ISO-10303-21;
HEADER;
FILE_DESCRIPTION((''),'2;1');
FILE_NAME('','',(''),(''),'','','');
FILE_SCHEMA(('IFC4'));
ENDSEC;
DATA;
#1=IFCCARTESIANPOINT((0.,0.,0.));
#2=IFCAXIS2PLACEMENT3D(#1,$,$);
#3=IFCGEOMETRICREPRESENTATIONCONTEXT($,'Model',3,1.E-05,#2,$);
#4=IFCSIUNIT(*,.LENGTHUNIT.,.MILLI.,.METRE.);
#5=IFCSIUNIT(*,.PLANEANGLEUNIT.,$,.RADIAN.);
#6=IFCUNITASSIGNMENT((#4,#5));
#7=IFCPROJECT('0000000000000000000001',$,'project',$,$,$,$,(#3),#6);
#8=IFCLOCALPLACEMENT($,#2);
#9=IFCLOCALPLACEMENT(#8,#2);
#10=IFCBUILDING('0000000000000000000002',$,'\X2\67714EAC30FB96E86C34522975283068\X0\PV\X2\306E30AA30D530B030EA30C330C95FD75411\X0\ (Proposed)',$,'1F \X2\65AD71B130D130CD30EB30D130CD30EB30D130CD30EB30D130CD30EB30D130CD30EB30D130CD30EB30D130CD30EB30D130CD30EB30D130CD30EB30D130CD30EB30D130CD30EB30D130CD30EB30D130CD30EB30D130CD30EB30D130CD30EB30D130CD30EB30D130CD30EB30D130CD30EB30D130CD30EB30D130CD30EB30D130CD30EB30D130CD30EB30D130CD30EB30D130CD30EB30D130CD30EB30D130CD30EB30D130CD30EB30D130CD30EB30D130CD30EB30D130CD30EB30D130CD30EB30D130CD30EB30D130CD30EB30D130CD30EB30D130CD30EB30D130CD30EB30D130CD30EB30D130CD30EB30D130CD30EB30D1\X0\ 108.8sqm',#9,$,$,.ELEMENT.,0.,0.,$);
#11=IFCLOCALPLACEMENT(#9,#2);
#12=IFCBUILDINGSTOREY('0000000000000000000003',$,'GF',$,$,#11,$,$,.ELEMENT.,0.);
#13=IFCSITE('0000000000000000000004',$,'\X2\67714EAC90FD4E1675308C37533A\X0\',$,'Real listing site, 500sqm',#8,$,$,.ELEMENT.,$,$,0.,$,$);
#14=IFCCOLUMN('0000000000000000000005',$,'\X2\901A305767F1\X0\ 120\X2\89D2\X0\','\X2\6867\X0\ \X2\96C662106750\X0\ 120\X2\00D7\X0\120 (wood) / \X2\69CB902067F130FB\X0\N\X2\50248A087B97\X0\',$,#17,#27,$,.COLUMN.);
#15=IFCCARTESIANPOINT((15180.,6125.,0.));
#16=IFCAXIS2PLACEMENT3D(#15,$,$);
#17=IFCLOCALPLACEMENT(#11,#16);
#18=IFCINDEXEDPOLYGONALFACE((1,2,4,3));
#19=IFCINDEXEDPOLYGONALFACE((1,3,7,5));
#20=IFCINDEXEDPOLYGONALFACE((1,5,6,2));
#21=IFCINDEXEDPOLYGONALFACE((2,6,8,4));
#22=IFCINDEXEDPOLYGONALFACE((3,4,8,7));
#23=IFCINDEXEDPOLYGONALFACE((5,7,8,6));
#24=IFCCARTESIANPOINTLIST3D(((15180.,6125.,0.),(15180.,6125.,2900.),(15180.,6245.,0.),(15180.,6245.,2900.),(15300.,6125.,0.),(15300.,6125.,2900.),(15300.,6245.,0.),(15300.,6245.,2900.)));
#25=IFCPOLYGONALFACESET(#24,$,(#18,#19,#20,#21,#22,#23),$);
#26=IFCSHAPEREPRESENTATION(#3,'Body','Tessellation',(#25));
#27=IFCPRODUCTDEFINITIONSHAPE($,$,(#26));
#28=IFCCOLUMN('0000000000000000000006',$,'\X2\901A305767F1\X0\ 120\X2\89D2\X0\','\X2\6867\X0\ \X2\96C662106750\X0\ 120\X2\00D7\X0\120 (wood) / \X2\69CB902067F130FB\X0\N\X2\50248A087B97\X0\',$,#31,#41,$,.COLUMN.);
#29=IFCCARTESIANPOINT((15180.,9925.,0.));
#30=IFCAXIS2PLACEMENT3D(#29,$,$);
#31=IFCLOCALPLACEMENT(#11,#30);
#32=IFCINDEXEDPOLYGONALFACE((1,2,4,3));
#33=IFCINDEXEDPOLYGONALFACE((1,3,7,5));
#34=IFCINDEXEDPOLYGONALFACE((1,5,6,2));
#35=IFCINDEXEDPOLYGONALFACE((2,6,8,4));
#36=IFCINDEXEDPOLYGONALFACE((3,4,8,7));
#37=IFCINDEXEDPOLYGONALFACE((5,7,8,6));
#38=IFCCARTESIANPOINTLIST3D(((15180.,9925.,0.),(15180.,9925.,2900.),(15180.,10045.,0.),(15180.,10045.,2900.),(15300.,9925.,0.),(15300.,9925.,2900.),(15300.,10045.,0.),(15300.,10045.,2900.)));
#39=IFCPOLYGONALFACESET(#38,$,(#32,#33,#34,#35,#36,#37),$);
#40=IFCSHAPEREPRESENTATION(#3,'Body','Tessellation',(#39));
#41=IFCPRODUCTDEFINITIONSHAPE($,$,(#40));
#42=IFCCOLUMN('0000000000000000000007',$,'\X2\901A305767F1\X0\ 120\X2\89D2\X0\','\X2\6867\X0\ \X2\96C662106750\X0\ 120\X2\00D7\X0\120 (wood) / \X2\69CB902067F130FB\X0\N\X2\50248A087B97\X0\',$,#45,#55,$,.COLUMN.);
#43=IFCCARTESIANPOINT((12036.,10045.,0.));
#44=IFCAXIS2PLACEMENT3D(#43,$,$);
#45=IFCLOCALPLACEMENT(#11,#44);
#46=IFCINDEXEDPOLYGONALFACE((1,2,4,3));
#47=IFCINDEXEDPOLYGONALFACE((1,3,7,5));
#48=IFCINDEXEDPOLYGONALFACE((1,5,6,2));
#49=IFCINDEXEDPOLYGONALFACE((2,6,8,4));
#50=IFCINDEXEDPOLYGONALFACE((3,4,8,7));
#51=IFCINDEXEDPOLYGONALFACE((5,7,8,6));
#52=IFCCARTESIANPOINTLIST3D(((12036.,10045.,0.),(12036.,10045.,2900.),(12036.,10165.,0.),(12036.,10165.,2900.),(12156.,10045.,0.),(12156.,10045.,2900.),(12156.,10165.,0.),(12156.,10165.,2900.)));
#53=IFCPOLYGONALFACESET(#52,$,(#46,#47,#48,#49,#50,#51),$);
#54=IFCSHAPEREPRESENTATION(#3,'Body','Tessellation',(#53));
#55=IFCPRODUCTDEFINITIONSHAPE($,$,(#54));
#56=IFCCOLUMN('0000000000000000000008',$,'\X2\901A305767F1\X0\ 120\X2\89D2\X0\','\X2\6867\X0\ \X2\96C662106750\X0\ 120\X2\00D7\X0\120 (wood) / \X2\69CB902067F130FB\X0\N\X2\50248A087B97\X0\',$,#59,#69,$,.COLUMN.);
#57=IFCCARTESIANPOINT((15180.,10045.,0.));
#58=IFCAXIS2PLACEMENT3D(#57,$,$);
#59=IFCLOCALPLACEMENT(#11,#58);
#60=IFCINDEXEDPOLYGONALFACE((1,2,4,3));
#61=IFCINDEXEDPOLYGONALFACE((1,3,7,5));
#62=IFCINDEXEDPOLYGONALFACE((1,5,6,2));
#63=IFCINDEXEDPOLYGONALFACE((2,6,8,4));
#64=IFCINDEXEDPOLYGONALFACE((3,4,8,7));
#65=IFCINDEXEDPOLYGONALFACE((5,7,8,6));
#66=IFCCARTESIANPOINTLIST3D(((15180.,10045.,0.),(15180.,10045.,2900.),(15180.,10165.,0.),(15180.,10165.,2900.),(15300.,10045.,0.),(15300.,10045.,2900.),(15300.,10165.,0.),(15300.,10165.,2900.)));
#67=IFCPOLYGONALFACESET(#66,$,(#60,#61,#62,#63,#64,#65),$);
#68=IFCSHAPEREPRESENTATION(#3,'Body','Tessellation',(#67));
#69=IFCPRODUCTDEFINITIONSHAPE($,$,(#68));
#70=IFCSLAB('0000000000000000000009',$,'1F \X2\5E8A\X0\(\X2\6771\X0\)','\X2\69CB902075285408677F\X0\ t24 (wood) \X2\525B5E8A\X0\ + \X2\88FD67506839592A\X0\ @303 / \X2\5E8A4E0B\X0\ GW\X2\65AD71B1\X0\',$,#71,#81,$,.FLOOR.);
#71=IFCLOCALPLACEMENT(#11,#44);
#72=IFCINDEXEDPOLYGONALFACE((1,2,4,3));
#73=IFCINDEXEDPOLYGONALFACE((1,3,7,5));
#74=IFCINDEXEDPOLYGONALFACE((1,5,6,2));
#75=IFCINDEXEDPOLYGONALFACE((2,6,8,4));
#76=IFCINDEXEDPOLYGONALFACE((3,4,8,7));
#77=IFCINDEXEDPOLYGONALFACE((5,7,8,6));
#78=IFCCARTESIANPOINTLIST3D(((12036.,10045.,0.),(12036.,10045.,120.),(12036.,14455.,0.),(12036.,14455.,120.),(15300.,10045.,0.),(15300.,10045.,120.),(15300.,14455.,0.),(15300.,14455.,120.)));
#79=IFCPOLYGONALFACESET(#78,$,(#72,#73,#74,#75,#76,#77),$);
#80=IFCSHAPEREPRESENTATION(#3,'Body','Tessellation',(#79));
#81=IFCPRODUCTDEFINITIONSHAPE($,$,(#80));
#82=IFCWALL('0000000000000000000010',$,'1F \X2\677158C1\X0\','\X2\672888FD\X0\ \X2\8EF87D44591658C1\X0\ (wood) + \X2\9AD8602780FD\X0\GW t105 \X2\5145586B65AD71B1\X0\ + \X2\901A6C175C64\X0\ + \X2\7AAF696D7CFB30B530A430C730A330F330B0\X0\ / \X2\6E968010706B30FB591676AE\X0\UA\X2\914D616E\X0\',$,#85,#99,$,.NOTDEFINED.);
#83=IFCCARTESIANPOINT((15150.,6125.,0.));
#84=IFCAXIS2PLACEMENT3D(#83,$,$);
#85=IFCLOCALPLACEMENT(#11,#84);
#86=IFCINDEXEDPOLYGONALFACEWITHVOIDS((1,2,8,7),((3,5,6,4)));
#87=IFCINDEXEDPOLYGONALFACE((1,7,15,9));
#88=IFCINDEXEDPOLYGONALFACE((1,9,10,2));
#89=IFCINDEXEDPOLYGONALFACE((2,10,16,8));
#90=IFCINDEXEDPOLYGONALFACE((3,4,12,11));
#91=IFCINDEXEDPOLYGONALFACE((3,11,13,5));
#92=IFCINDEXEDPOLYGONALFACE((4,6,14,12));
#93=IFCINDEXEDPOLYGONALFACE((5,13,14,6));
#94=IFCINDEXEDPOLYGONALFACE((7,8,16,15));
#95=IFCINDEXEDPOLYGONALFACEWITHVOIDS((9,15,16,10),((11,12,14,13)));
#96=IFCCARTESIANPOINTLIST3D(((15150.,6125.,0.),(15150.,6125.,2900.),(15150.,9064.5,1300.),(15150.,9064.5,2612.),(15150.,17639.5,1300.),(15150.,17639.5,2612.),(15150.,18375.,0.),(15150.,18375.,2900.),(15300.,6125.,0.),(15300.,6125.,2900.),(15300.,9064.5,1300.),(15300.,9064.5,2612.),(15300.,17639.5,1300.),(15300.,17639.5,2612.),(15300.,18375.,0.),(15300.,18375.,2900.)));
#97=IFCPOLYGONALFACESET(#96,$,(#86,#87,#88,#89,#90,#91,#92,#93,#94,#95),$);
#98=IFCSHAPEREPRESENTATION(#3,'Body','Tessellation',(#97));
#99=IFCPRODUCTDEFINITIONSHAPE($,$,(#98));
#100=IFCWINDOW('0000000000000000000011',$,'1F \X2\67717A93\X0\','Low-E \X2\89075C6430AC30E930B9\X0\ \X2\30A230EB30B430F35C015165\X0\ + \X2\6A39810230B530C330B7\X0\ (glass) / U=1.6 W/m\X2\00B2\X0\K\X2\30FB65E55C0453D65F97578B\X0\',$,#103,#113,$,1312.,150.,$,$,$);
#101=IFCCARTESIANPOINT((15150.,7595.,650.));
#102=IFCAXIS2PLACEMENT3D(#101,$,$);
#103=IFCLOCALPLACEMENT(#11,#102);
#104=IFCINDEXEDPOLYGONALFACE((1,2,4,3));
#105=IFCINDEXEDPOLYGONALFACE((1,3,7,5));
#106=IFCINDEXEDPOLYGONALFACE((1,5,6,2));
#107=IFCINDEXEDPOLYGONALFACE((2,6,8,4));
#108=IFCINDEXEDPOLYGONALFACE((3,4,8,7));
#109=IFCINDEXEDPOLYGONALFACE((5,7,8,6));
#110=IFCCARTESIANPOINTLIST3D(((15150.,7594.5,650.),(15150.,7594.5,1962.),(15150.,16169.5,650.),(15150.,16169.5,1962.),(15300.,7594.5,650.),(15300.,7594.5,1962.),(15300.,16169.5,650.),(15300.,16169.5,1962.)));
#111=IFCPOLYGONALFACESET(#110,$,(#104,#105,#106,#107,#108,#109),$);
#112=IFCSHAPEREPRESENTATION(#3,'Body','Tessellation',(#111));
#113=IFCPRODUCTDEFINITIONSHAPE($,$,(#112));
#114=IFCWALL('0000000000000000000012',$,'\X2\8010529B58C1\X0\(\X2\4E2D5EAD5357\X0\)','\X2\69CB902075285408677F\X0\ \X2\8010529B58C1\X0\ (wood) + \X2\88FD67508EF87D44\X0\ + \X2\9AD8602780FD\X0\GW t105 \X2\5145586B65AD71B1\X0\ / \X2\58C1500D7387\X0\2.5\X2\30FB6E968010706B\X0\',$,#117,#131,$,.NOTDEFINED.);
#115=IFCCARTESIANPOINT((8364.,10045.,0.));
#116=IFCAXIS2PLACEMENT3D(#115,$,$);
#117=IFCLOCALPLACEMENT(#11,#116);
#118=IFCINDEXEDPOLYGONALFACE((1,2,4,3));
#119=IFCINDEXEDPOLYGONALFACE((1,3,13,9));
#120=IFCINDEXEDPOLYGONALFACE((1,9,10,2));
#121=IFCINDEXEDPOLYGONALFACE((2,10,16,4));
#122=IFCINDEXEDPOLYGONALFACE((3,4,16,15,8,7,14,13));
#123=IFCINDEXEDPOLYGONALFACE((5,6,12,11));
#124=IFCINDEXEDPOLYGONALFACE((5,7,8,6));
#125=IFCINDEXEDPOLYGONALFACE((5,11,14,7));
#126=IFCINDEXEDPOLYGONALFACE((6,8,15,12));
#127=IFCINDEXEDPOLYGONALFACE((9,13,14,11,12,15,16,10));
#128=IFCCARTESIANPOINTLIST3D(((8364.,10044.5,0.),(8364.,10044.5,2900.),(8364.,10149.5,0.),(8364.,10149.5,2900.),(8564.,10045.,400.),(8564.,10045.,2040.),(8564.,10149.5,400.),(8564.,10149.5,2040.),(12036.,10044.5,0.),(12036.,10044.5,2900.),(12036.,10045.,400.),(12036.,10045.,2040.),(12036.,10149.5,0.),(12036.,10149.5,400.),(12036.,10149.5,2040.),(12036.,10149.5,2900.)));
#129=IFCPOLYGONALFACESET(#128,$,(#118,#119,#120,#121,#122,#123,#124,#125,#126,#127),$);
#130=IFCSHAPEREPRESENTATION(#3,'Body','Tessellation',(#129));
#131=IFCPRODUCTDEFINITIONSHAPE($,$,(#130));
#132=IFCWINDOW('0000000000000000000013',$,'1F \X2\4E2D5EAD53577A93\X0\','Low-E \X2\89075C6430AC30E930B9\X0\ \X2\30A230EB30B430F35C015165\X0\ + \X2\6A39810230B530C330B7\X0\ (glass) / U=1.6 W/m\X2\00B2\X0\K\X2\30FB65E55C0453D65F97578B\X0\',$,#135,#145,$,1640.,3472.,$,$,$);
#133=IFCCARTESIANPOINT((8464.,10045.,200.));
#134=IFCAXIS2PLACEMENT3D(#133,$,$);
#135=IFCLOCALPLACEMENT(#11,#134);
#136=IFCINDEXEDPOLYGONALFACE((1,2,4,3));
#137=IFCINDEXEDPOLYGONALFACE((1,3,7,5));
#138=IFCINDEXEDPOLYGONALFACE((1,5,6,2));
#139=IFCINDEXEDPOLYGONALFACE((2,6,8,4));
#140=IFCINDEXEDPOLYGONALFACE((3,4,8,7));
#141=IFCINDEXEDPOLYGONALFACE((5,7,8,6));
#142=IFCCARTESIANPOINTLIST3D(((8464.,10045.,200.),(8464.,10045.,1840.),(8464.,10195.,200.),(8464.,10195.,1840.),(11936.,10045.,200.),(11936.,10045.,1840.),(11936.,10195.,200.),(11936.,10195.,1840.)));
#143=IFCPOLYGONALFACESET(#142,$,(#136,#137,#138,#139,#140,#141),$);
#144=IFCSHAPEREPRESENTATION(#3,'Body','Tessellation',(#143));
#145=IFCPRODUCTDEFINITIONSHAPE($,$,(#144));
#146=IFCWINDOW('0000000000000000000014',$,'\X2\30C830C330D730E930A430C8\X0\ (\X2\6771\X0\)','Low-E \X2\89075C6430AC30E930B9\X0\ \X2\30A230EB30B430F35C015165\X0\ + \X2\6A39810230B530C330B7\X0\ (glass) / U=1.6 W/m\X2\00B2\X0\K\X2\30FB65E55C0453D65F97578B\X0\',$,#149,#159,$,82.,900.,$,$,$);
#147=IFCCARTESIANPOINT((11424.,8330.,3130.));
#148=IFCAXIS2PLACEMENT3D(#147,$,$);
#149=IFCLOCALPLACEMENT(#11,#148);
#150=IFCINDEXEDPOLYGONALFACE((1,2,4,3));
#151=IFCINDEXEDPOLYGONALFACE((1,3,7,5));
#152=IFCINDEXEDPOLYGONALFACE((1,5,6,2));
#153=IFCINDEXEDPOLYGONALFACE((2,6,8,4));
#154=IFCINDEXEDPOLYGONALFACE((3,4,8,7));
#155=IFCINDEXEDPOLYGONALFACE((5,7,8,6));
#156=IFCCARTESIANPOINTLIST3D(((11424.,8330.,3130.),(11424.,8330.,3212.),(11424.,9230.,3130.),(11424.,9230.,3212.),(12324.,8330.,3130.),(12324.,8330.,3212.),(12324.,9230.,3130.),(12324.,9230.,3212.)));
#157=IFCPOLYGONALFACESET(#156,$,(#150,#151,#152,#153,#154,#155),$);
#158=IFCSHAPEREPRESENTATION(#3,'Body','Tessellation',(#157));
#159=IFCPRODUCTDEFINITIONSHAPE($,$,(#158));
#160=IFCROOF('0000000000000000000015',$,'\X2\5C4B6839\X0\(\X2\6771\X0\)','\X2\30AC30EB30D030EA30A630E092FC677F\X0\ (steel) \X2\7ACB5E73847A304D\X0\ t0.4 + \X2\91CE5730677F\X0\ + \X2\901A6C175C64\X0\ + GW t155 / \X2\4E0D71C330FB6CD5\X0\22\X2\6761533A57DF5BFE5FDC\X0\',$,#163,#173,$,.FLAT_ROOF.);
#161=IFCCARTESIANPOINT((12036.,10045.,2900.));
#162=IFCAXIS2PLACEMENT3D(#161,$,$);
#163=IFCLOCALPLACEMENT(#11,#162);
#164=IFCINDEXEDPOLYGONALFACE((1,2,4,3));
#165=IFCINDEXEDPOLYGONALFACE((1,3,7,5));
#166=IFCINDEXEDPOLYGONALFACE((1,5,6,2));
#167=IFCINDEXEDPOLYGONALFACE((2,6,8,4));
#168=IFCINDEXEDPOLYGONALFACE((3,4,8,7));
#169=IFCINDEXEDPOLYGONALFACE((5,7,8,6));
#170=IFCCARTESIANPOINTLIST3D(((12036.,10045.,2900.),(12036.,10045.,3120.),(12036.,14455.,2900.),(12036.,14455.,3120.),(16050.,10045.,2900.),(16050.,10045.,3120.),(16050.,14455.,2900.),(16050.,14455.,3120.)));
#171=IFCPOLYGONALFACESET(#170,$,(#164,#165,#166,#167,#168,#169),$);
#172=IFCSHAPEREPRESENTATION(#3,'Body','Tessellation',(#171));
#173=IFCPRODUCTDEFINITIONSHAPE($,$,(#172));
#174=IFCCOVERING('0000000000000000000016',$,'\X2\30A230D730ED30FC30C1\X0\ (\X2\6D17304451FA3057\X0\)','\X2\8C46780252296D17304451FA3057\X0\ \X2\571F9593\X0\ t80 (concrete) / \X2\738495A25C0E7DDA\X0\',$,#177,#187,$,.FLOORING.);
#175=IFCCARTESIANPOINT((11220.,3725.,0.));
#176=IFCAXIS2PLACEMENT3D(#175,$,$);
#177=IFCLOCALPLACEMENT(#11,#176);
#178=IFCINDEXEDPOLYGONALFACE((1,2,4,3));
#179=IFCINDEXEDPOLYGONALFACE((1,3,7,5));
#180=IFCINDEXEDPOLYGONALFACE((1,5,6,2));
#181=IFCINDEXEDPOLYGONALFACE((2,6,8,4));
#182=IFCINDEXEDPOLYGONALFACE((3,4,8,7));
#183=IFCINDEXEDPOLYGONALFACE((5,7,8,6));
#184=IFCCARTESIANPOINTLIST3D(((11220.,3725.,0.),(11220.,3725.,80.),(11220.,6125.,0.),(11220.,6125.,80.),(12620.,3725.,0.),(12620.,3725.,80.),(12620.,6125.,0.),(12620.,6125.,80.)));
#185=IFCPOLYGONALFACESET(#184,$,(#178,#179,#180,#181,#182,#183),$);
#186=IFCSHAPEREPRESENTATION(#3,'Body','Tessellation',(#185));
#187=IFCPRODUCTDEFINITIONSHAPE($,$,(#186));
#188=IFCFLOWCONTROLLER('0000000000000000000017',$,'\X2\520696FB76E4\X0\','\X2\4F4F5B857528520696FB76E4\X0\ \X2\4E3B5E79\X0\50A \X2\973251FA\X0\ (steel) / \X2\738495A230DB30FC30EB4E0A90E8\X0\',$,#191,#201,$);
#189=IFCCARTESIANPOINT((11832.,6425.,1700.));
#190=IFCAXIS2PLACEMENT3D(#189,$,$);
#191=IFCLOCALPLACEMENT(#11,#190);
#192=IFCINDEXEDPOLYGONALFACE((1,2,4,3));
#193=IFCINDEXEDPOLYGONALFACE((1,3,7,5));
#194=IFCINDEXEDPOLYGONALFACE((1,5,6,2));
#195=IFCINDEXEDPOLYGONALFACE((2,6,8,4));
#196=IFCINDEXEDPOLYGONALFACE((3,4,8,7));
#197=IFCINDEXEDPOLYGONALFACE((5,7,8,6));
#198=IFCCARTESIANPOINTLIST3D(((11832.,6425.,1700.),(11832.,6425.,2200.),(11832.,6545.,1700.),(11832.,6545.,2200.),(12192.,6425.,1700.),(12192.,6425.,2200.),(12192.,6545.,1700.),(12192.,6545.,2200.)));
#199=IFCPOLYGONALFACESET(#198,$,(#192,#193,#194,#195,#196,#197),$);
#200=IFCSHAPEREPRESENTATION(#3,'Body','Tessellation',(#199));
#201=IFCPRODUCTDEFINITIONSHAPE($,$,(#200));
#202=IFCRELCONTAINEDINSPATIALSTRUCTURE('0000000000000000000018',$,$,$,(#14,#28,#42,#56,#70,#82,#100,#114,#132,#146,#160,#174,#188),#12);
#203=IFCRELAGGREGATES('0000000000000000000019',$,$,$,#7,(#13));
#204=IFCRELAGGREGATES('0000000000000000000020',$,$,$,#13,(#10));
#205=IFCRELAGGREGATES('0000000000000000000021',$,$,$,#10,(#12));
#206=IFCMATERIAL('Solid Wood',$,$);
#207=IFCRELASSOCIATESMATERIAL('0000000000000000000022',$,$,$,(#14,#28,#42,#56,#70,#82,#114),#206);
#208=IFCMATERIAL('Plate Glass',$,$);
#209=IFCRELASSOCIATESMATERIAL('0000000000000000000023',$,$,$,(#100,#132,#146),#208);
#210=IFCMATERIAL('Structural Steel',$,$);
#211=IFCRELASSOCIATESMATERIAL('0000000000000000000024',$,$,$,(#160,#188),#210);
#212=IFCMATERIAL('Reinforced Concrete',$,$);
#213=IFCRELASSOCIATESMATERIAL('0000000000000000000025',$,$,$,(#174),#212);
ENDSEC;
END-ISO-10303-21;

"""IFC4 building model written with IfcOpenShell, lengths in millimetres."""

from ifc_helpers import new_model, si_unit, frame, frame_2d, origin, place, context, project, spatial, rectangle, extrude, material, element, fill, save


model = new_model("IFC4")

# Units and contexts
model_context = context("Model", 3, precision=1e-05, world=origin())
ifc_project = project(units=[si_unit("LENGTHUNIT", "METRE", prefix="MILLI"), si_unit("PLANEANGLEUNIT", "RADIAN")], contexts=[model_context])

# Site, building, storey
site_placement = place(None, origin())
site = spatial("IfcSite", under=ifc_project, at=site_placement, Name="東京都世田谷区", ObjectType="Real listing site, 500sqm", CompositionType="ELEMENT", RefElevation=0.0)
building_placement = place(site_placement, origin())
building = spatial("IfcBuilding", under=site, at=building_placement, Name="東京・雨水利用とPVのオフグリッド志向 (Proposed)", ObjectType="1F 断熱パネルパネルパネルパネルパネルパネルパネルパネルパネルパネルパネルパネルパネルパネルパネルパネルパネルパネルパネルパネルパネルパネルパネルパネルパネルパネルパネルパネルパネルパネルパネルパネルパネルパネルパネルパネルパネルパネルパネルパ 108.8sqm", CompositionType="ELEMENT", ElevationOfRefHeight=0.0, ElevationOfTerrain=0.0)
storey_placement = place(building_placement, origin())
storey = spatial("IfcBuildingStorey", under=building, at=storey_placement, Name="GF", CompositionType="ELEMENT", Elevation=0.0)

# Columns
ifc_material_1 = material(Name="Solid Wood")
column_1_placement = place(storey_placement, frame((15180.0, 6125.0, 0.0)))
element("IfcColumn", 1, at=column_1_placement, inside=storey, material=ifc_material_1, Name="通し柱 120角", Description="桧 集成材 120×120 (wood) / 構造柱・N値計算", PredefinedType="COLUMN", context=model_context, shape_type="SweptSolid", body=[
    extrude(rectangle(XDim=120.0, YDim=120.0, at=frame_2d((60.0, 60.0))), frame((15180.0, 6125.0, 0.0)), (0.0, 0.0, 1.0), 2900.0),
])
column_2_placement = place(storey_placement, frame((15180.0, 9925.0, 0.0)))
element("IfcColumn", 2, at=column_2_placement, inside=storey, material=ifc_material_1, Name="通し柱 120角", Description="桧 集成材 120×120 (wood) / 構造柱・N値計算", PredefinedType="COLUMN", context=model_context, shape_type="SweptSolid", body=[
    extrude(rectangle(XDim=120.0, YDim=120.0, at=frame_2d((60.0, 60.0))), frame((15180.0, 9925.0, 0.0)), (0.0, 0.0, 1.0), 2900.0),
])
column_3_placement = place(storey_placement, frame((12036.0, 10045.0, 0.0)))
element("IfcColumn", 3, at=column_3_placement, inside=storey, material=ifc_material_1, Name="通し柱 120角", Description="桧 集成材 120×120 (wood) / 構造柱・N値計算", PredefinedType="COLUMN", context=model_context, shape_type="SweptSolid", body=[
    extrude(rectangle(XDim=120.0, YDim=120.0, at=frame_2d((60.0, 60.0))), frame((12036.0, 10045.0, 0.0)), (0.0, 0.0, 1.0), 2900.0),
])
column_4_placement = place(storey_placement, frame((15180.0, 10045.0, 0.0)))
element("IfcColumn", 4, at=column_4_placement, inside=storey, material=ifc_material_1, Name="通し柱 120角", Description="桧 集成材 120×120 (wood) / 構造柱・N値計算", PredefinedType="COLUMN", context=model_context, shape_type="SweptSolid", body=[
    extrude(rectangle(XDim=120.0, YDim=120.0, at=frame_2d((60.0, 60.0))), frame((15180.0, 10045.0, 0.0)), (0.0, 0.0, 1.0), 2900.0),
])

# Slab
slab_placement = place(storey_placement, frame((12036.0, 10045.0, 0.0)))
element("IfcSlab", 5, at=slab_placement, inside=storey, material=ifc_material_1, Name="1F 床(東)", Description="構造用合板 t24 (wood) 剛床 + 製材根太 @303 / 床下 GW断熱", PredefinedType="FLOOR", context=model_context, shape_type="SweptSolid", body=[
    extrude(rectangle(XDim=3264.0, YDim=4410.0, at=frame_2d((1632.0, 2205.0))), frame((12036.0, 10045.0, 0.0)), (0.0, 0.0, 1.0), 120.0),
])

# Walls, openings, windows
wall_1_placement = place(storey_placement, frame((15150.0, 6125.0, 0.0)))
wall_1 = element("IfcWall", 6, at=wall_1_placement, inside=storey, material=ifc_material_1, Name="1F 東壁", Description="木製 軸組外壁 (wood) + 高性能GW t105 充填断熱 + 通気層 + 窯業系サイディング / 準耐火・外皮UA配慮", PredefinedType="NOTDEFINED", context=model_context, shape_type="SweptSolid", body=[
    extrude(rectangle(XDim=150.0, YDim=12250.0, at=frame_2d((75.0, 6125.0))), frame((15150.0, 6125.0, 0.0)), (0.0, 0.0, 1.0), 2900.0),
])
opening_1_placement = place(storey_placement, frame((15150.0, 7595.0, 650.0)))
opening_1 = element("IfcOpeningElement", 7, at=opening_1_placement, cuts=wall_1, PredefinedType="NOTDEFINED", context=model_context, shape_type="SweptSolid", body=[
    extrude(rectangle(XDim=150.0, YDim=8575.0, at=frame_2d((75.0, 4287.0))), frame((15150.0, 7595.0, 650.0)), (0.0, 0.0, 1.0), 1312.0),
])
ifc_material_2 = material(Name="Plate Glass")
window_1_placement = place(storey_placement, frame((15150.0, 7595.0, 650.0)))
window_1 = element("IfcWindow", 8, at=window_1_placement, inside=storey, material=ifc_material_2, Name="1F 東窓", Description="Low-E 複層ガラス アルゴン封入 + 樹脂サッシ (glass) / U=1.6 W/m²K・日射取得型", OverallHeight=1312.0, OverallWidth=150.0, context=model_context, shape_type="SweptSolid", body=[
    extrude(rectangle(XDim=150.0, YDim=8575.0, at=frame_2d((75.0, 4287.0))), frame((15150.0, 7595.0, 650.0)), (0.0, 0.0, 1.0), 1312.0),
])
fill(opening_1, window_1)
wall_2_placement = place(storey_placement, frame((8364.0, 10045.0, 0.0)))
wall_2 = element("IfcWall", 9, at=wall_2_placement, inside=storey, material=ifc_material_1, Name="耐力壁(中庭南)", Description="構造用合板 耐力壁 (wood) + 製材軸組 + 高性能GW t105 充填断熱 / 壁倍率2.5・準耐火", PredefinedType="NOTDEFINED", context=model_context, shape_type="SweptSolid", body=[
    extrude(rectangle(XDim=3672.0, YDim=105.0, at=frame_2d((1836.0, 52.0))), frame((8364.0, 10045.0, 0.0)), (0.0, 0.0, 1.0), 2900.0),
])
opening_2_placement = place(storey_placement, frame((8464.0, 10045.0, 200.0)))
opening_2 = element("IfcOpeningElement", 10, at=opening_2_placement, cuts=wall_2, PredefinedType="NOTDEFINED", context=model_context, shape_type="SweptSolid", body=[
    extrude(rectangle(XDim=3472.0, YDim=150.0, at=frame_2d((1736.0, 75.0))), frame((8464.0, 10045.0, 200.0)), (0.0, 0.0, 1.0), 1640.0),
])
window_2_placement = place(storey_placement, frame((8464.0, 10045.0, 200.0)))
window_2 = element("IfcWindow", 11, at=window_2_placement, inside=storey, material=ifc_material_2, Name="1F 中庭南窓", Description="Low-E 複層ガラス アルゴン封入 + 樹脂サッシ (glass) / U=1.6 W/m²K・日射取得型", OverallHeight=1640.0, OverallWidth=3472.0, context=model_context, shape_type="SweptSolid", body=[
    extrude(rectangle(XDim=3472.0, YDim=150.0, at=frame_2d((1736.0, 75.0))), frame((8464.0, 10045.0, 200.0)), (0.0, 0.0, 1.0), 1640.0),
])
fill(opening_2, window_2)

# Window
window_3_placement = place(storey_placement, frame((11424.0, 8330.0, 3130.0)))
element("IfcWindow", 12, at=window_3_placement, inside=storey, material=ifc_material_2, Name="トップライト (東)", Description="Low-E 複層ガラス アルゴン封入 + 樹脂サッシ (glass) / U=1.6 W/m²K・日射取得型", OverallHeight=82.0, OverallWidth=900.0, context=model_context, shape_type="SweptSolid", body=[
    extrude(rectangle(XDim=900.0, YDim=900.0, at=frame_2d((450.0, 450.0))), frame((11424.0, 8330.0, 3130.0)), (0.0, 0.0, 1.0), 82.0),
])

# Roof
ifc_material_3 = material(Name="Structural Steel")
roof_placement = place(storey_placement, frame((12036.0, 10045.0, 2900.0)))
element("IfcRoof", 13, at=roof_placement, inside=storey, material=ifc_material_3, Name="屋根(東)", Description="ガルバリウム鋼板 (steel) 立平葺き t0.4 + 野地板 + 通気層 + GW t155 / 不燃・法22条区域対応", PredefinedType="FLAT_ROOF", context=model_context, shape_type="SweptSolid", body=[
    extrude(rectangle(XDim=4014.0, YDim=4410.0, at=frame_2d((2007.0, 2205.0))), frame((12036.0, 10045.0, 2900.0)), (0.0, 0.0, 1.0), 220.0),
])

# Covering
ifc_material_4 = material(Name="Reinforced Concrete")
covering_placement = place(storey_placement, frame((11220.0, 3725.0, 0.0)))
element("IfcCovering", 14, at=covering_placement, inside=storey, material=ifc_material_4, Name="アプローチ (洗い出し)", Description="豆砂利洗い出し 土間 t80 (concrete) / 玄関導線", PredefinedType="FLOORING", context=model_context, shape_type="SweptSolid", body=[
    extrude(rectangle(XDim=1400.0, YDim=2400.0, at=frame_2d((700.0, 1200.0))), frame((11220.0, 3725.0, 0.0)), (0.0, 0.0, 1.0), 80.0),
])

# Flow controller
flow_controller_placement = place(storey_placement, frame((11832.0, 6425.0, 1700.0)))
element("IfcFlowController", 15, at=flow_controller_placement, inside=storey, material=ifc_material_3, Name="分電盤", Description="住宅用分電盤 主幹50A 露出 (steel) / 玄関ホール上部", context=model_context, shape_type="SweptSolid", body=[
    extrude(rectangle(XDim=360.0, YDim=120.0, at=frame_2d((180.0, 60.0))), frame((11832.0, 6425.0, 1700.0)), (0.0, 0.0, 1.0), 500.0),
])

save(model, "model.ifc")
